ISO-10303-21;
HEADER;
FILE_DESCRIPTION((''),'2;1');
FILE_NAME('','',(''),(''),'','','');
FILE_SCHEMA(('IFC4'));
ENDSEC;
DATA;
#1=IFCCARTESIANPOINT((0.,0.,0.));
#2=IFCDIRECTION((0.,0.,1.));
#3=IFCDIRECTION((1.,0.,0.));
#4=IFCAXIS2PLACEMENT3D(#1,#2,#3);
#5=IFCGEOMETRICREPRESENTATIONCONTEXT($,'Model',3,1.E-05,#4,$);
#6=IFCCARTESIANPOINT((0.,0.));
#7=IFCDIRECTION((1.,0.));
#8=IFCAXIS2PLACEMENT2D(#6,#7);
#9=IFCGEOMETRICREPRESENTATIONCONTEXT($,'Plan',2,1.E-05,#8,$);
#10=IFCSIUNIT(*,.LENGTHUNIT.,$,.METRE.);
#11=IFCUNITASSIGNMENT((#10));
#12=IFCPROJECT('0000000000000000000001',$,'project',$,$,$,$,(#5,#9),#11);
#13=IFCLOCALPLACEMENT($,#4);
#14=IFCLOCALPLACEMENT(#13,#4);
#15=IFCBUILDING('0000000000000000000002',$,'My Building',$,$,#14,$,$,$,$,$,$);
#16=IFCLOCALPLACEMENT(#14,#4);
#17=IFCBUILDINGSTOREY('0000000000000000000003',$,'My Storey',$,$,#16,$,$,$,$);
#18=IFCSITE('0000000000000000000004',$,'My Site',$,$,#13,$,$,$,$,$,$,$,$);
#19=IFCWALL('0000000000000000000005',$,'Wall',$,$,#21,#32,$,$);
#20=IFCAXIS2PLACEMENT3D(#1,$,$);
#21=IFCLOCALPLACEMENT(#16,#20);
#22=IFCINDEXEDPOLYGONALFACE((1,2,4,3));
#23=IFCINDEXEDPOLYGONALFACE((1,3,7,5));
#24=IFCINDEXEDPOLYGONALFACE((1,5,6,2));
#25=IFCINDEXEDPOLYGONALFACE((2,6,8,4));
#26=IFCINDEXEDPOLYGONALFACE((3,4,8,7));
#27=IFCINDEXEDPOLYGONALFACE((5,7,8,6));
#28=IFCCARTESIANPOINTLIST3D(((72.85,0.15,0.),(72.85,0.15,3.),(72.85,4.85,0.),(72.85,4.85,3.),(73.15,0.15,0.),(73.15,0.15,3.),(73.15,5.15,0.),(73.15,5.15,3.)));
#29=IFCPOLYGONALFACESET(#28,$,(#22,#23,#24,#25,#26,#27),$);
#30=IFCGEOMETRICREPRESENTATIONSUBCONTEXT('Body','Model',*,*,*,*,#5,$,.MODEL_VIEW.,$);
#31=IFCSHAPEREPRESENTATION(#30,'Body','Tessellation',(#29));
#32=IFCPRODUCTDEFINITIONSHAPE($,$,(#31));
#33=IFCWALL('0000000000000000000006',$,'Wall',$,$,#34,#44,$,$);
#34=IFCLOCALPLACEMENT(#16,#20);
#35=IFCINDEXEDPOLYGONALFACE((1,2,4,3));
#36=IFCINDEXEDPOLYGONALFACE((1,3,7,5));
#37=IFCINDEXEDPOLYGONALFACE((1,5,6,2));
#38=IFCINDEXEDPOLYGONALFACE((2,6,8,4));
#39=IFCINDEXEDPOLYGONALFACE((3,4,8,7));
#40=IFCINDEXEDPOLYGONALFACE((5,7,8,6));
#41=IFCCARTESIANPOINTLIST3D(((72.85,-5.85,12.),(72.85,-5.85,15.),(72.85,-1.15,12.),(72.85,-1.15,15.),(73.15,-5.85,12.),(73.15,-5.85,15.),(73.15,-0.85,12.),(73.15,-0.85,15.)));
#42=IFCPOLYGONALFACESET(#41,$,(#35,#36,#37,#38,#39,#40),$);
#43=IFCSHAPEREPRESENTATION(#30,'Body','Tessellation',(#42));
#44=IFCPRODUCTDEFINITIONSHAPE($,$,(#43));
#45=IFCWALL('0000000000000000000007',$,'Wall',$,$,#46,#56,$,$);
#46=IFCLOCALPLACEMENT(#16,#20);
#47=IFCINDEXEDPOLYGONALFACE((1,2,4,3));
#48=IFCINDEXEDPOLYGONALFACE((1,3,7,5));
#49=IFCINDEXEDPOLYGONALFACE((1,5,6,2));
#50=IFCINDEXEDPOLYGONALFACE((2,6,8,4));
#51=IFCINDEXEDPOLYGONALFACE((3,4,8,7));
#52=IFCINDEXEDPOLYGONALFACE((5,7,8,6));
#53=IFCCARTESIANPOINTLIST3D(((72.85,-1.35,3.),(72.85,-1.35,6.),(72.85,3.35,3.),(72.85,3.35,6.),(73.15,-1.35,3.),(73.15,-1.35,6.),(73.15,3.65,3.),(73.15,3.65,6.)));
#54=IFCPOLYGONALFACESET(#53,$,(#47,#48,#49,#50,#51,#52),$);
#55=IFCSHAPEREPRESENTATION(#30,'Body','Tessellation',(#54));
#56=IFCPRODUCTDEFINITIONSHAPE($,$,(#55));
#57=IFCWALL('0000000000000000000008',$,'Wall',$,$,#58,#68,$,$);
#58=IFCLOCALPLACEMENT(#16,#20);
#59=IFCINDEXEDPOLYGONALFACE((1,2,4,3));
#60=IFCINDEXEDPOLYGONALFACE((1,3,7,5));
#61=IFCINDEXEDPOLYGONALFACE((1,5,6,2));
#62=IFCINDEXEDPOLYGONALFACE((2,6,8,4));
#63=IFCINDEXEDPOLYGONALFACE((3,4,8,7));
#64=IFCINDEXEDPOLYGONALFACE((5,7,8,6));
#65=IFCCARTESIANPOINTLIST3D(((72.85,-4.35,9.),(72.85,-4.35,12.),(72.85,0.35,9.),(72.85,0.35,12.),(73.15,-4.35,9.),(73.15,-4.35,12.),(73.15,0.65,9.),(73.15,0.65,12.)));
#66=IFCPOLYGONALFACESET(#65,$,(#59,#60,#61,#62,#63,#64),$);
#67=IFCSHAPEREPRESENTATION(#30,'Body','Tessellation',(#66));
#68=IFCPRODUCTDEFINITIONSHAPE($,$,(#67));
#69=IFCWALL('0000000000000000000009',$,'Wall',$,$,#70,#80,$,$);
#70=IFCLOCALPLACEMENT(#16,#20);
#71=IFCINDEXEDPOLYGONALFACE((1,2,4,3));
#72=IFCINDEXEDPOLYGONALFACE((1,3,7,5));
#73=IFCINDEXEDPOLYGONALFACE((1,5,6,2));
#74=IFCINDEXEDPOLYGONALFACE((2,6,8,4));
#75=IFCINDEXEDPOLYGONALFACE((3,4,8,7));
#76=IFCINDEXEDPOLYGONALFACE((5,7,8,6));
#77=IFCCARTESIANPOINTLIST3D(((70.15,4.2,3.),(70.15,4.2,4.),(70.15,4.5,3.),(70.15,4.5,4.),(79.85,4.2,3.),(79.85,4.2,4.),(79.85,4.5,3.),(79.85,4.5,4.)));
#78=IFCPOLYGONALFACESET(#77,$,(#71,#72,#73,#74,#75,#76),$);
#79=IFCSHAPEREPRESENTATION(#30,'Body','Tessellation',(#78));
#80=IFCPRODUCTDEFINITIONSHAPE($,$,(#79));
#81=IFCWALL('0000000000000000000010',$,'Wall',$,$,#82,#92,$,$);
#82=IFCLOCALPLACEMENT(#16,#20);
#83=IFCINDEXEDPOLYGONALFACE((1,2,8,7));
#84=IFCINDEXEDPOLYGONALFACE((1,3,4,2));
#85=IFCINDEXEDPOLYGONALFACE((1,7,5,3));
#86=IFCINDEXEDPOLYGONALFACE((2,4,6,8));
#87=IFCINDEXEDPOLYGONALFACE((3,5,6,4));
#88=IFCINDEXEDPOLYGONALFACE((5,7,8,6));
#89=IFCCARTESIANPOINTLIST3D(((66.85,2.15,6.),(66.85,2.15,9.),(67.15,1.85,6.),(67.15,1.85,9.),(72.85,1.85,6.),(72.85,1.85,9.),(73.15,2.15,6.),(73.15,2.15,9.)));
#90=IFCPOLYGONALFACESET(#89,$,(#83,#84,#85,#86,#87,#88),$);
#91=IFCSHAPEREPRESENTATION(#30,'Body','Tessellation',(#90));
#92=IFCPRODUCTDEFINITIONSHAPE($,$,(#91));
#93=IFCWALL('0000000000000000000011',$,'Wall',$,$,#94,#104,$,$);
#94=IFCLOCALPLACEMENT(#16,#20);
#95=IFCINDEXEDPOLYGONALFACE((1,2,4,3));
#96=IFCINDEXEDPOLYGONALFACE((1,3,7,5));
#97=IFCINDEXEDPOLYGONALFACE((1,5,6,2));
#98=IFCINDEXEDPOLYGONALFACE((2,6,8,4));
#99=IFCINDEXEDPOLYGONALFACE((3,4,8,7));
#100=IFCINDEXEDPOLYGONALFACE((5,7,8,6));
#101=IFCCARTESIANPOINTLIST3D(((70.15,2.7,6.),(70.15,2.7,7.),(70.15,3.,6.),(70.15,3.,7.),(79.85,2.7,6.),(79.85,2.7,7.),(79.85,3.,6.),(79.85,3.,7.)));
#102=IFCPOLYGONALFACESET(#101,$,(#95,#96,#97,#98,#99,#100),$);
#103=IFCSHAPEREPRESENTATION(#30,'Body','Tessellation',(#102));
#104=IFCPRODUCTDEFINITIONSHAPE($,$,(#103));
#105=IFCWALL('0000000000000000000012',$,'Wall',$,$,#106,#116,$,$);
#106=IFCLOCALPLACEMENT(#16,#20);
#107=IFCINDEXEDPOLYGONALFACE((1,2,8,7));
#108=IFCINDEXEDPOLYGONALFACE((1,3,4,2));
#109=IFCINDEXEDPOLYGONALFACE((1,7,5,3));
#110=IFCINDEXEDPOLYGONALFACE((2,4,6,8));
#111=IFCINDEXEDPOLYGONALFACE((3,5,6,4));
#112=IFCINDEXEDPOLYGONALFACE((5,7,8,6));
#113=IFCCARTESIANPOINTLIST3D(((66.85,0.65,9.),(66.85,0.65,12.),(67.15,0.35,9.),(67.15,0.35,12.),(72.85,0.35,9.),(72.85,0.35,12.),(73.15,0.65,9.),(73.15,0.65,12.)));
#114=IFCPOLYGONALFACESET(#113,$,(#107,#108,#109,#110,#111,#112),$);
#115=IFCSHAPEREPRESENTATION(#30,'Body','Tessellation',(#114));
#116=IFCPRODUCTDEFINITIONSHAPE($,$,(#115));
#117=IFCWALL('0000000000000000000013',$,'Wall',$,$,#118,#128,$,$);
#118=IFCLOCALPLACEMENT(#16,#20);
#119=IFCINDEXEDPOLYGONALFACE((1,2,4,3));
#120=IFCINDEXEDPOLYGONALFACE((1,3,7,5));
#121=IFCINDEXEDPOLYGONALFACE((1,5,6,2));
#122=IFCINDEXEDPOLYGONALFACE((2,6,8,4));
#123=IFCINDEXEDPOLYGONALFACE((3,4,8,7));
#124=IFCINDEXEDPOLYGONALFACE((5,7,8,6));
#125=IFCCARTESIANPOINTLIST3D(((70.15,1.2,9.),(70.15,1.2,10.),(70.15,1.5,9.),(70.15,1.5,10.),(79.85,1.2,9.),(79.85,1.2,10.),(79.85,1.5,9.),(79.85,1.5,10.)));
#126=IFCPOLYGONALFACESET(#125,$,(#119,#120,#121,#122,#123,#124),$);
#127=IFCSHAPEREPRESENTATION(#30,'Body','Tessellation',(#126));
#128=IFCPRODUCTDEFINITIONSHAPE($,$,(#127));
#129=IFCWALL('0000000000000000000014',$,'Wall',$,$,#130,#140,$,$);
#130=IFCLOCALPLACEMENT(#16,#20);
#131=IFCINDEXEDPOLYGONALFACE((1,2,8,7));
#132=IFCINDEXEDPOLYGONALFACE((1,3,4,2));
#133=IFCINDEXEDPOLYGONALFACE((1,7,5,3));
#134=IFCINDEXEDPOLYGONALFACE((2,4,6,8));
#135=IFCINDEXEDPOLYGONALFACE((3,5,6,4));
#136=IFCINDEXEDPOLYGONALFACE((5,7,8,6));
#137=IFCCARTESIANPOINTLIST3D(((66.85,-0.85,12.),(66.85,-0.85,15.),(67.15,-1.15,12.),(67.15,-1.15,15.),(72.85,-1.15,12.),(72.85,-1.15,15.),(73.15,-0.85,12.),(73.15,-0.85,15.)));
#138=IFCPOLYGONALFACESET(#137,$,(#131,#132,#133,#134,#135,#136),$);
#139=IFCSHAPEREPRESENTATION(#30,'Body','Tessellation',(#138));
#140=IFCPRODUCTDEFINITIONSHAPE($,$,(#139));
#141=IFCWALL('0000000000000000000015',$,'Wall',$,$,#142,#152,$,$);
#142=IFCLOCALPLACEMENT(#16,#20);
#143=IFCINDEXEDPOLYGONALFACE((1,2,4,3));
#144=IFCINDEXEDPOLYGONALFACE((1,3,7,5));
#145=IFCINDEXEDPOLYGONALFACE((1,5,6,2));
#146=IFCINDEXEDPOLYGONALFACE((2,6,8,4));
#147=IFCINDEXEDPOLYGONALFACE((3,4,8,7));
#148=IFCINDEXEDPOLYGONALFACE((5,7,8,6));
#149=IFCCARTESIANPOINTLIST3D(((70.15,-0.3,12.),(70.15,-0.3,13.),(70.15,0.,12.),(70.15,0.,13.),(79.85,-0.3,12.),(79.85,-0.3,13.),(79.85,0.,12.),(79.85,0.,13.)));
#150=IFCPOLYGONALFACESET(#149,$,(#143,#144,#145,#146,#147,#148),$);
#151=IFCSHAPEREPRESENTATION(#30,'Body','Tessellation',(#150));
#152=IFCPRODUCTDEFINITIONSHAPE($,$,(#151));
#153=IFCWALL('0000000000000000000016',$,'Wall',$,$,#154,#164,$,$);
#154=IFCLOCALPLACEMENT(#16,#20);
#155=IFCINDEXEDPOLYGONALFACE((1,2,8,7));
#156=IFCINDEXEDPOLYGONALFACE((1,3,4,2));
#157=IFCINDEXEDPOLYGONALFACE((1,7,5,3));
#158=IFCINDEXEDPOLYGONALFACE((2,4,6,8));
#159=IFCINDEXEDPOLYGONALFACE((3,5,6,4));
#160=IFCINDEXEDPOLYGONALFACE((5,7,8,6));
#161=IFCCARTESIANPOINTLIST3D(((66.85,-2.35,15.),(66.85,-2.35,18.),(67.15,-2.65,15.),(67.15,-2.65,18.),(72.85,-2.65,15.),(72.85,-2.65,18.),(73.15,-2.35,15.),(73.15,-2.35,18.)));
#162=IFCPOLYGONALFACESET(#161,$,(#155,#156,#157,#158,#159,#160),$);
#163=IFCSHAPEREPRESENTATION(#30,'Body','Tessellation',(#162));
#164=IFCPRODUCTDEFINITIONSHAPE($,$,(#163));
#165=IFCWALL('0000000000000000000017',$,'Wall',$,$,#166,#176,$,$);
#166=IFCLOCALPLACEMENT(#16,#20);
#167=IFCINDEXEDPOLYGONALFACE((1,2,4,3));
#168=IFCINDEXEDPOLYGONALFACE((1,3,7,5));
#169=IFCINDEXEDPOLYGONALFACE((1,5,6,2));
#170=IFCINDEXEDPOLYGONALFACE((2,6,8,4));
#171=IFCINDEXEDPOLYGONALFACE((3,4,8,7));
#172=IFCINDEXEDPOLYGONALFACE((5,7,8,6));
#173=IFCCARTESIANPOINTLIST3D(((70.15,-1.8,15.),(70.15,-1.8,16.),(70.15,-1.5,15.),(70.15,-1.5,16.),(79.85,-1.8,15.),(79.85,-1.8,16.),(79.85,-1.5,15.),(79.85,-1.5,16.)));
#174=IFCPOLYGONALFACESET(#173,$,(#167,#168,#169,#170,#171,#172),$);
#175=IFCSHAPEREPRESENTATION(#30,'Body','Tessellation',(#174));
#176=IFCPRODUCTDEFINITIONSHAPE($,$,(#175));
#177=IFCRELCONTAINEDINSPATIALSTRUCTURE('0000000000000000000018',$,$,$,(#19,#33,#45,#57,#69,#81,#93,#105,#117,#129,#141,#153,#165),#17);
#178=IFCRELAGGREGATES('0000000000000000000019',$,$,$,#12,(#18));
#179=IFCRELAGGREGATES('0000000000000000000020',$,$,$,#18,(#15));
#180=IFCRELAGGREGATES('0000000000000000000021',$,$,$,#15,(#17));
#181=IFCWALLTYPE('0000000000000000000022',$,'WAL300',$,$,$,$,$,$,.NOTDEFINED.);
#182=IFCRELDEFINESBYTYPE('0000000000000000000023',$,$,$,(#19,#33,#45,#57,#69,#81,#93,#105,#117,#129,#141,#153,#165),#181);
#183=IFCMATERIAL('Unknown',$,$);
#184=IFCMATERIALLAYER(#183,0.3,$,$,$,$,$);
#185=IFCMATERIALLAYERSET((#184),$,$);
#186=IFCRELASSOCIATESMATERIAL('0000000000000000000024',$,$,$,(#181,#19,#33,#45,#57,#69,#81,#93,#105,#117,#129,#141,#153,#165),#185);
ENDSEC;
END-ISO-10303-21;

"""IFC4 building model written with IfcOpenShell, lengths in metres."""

from ifc_helpers import new_model, si_unit, frame, origin_with_axes, origin_2d_with_axis, place, context, subcontext, project, spatial, line, indexed_curve, outline, extrude, material, layer, layer_set, layer_usage, type_object, element, save


model = new_model("IFC4")

# Units and contexts
model_context = context("Model", 3, precision=1e-05, world=origin_with_axes())
plan_context = context("Plan", 2, precision=1e-05, world=origin_2d_with_axis())
body_context = subcontext(model_context, "Body", "Model", "MODEL_VIEW")
ifc_project = project(units=[si_unit("LENGTHUNIT", "METRE")], contexts=[model_context, plan_context])

# Site, building, storey
site_placement = place(None, origin_with_axes())
site = spatial("IfcSite", under=ifc_project, at=site_placement, Name="My Site")
building_placement = place(site_placement, origin_with_axes())
building = spatial("IfcBuilding", under=site, at=building_placement, Name="My Building")
storey_placement = place(building_placement, origin_with_axes())
storey = spatial("IfcBuildingStorey", under=building, at=storey_placement, Name="My Storey")

# Walls
ifc_material = material(Name="Unknown")
ifc_layer = layer(ifc_material, 0.3)
ifc_layer_set = layer_set([ifc_layer])
wall_type = type_object("IfcWallType", Name="WAL300", PredefinedType="NOTDEFINED", material=ifc_layer_set)
ifc_layer_usage_1 = layer_usage(ifc_layer_set, "AXIS2", "POSITIVE", -0.15)
wall_1_placement = place(storey_placement, frame((73.0, 0.0, 0.0), z_axis=(0.0, 0.0, 1.0), x_axis=(0.0, 1.0, 0.0)))
element("IfcWall", 1, at=wall_1_placement, inside=storey, type_object=wall_type, material=ifc_layer_usage_1, Name="Wall", context=body_context, shape_type="SweptSolid", body=[
    extrude(outline(indexed_curve([(0.15, -0.15), (0.15, 0.15), (4.85, 0.15), (5.15, -0.15)], segments=[line(1, 2, 3, 4, 1)])), origin_with_axes(), (0.0, 0.0, 1.0), 3.0),
])
ifc_layer_usage_2 = layer_usage(ifc_layer_set, "AXIS2", "POSITIVE", -0.15)
wall_2_placement = place(storey_placement, frame((73.0, -6.0, 12.0), z_axis=(0.0, 0.0, 1.0), x_axis=(0.0, 1.0, 0.0)))
element("IfcWall", 2, at=wall_2_placement, inside=storey, type_object=wall_type, material=ifc_layer_usage_2, Name="Wall", context=body_context, shape_type="SweptSolid", body=[
    extrude(outline(indexed_curve([(0.15, -0.15), (0.15, 0.15), (4.85, 0.15), (5.15, -0.15)], segments=[line(1, 2, 3, 4, 1)])), origin_with_axes(), (0.0, 0.0, 1.0), 3.0),
])
ifc_layer_usage_3 = layer_usage(ifc_layer_set, "AXIS2", "POSITIVE", -0.15)
wall_3_placement = place(storey_placement, frame((73.0, -1.5, 3.0), z_axis=(0.0, 0.0, 1.0), x_axis=(0.0, 1.0, 0.0)))
element("IfcWall", 3, at=wall_3_placement, inside=storey, type_object=wall_type, material=ifc_layer_usage_3, Name="Wall", context=body_context, shape_type="SweptSolid", body=[
    extrude(outline(indexed_curve([(0.15, -0.15), (0.15, 0.15), (4.85, 0.15), (5.15, -0.15)], segments=[line(1, 2, 3, 4, 1)])), origin_with_axes(), (0.0, 0.0, 1.0), 3.0),
])
ifc_layer_usage_4 = layer_usage(ifc_layer_set, "AXIS2", "POSITIVE", -0.15)
wall_4_placement = place(storey_placement, frame((73.0, -4.5, 9.0), z_axis=(0.0, 0.0, 1.0), x_axis=(0.0, 1.0, 0.0)))
element("IfcWall", 4, at=wall_4_placement, inside=storey, type_object=wall_type, material=ifc_layer_usage_4, Name="Wall", context=body_context, shape_type="SweptSolid", body=[
    extrude(outline(indexed_curve([(0.15, -0.15), (0.15, 0.15), (4.85, 0.15), (5.15, -0.15)], segments=[line(1, 2, 3, 4, 1)])), origin_with_axes(), (0.0, 0.0, 1.0), 3.0),
])
ifc_layer_usage_5 = layer_usage(ifc_layer_set, "AXIS2", "POSITIVE", -0.3)
wall_5_placement = place(storey_placement, frame((70.15, 4.5, 3.0), z_axis=(0.0, 0.0, 1.0), x_axis=(1.0, 0.0, 0.0)))
element("IfcWall", 5, at=wall_5_placement, inside=storey, type_object=wall_type, material=ifc_layer_usage_5, Name="Wall", context=body_context, shape_type="SweptSolid", body=[
    extrude(outline(indexed_curve([(0.0, -0.3), (0.0, 0.0), (9.7, 0.0), (9.7, -0.3)], segments=[line(1, 2, 3, 4, 1)])), origin_with_axes(), (0.0, 0.0, 1.0), 1.0),
])
ifc_layer_usage_6 = layer_usage(ifc_layer_set, "AXIS2", "POSITIVE", -0.15)
wall_6_placement = place(storey_placement, frame((67.0, 2.0, 6.0), z_axis=(0.0, 0.0, 1.0), x_axis=(1.0, 0.0, 0.0)))
element("IfcWall", 6, at=wall_6_placement, inside=storey, type_object=wall_type, material=ifc_layer_usage_6, Name="Wall", context=body_context, shape_type="SweptSolid", body=[
    extrude(outline(indexed_curve([(0.15, -0.15), (-0.15, 0.15), (6.15, 0.15), (5.85, -0.15)], segments=[line(1, 2, 3, 4, 1)])), origin_with_axes(), (0.0, 0.0, 1.0), 3.0),
])
ifc_layer_usage_7 = layer_usage(ifc_layer_set, "AXIS2", "POSITIVE", -0.3)
wall_7_placement = place(storey_placement, frame((70.15, 3.0, 6.0), z_axis=(0.0, 0.0, 1.0), x_axis=(1.0, 0.0, 0.0)))
element("IfcWall", 7, at=wall_7_placement, inside=storey, type_object=wall_type, material=ifc_layer_usage_7, Name="Wall", context=body_context, shape_type="SweptSolid", body=[
    extrude(outline(indexed_curve([(0.0, -0.3), (0.0, 0.0), (9.7, 0.0), (9.7, -0.3)], segments=[line(1, 2, 3, 4, 1)])), origin_with_axes(), (0.0, 0.0, 1.0), 1.0),
])
ifc_layer_usage_8 = layer_usage(ifc_layer_set, "AXIS2", "POSITIVE", -0.15)
wall_8_placement = place(storey_placement, frame((67.0, 0.5, 9.0), z_axis=(0.0, 0.0, 1.0), x_axis=(1.0, 0.0, 0.0)))
element("IfcWall", 8, at=wall_8_placement, inside=storey, type_object=wall_type, material=ifc_layer_usage_8, Name="Wall", context=body_context, shape_type="SweptSolid", body=[
    extrude(outline(indexed_curve([(0.15, -0.15), (-0.15, 0.15), (6.15, 0.15), (5.85, -0.15)], segments=[line(1, 2, 3, 4, 1)])), origin_with_axes(), (0.0, 0.0, 1.0), 3.0),
])
ifc_layer_usage_9 = layer_usage(ifc_layer_set, "AXIS2", "POSITIVE", -0.3)
wall_9_placement = place(storey_placement, frame((70.15, 1.5, 9.0), z_axis=(0.0, 0.0, 1.0), x_axis=(1.0, 0.0, 0.0)))
element("IfcWall", 9, at=wall_9_placement, inside=storey, type_object=wall_type, material=ifc_layer_usage_9, Name="Wall", context=body_context, shape_type="SweptSolid", body=[
    extrude(outline(indexed_curve([(0.0, -0.3), (0.0, 0.0), (9.7, 0.0), (9.7, -0.3)], segments=[line(1, 2, 3, 4, 1)])), origin_with_axes(), (0.0, 0.0, 1.0), 1.0),
])
ifc_layer_usage_10 = layer_usage(ifc_layer_set, "AXIS2", "POSITIVE", -0.15)
wall_10_placement = place(storey_placement, frame((67.0, -1.0, 12.0), z_axis=(0.0, 0.0, 1.0), x_axis=(1.0, 0.0, 0.0)))
element("IfcWall", 10, at=wall_10_placement, inside=storey, type_object=wall_type, material=ifc_layer_usage_10, Name="Wall", context=body_context, shape_type="SweptSolid", body=[
    extrude(outline(indexed_curve([(0.15, -0.15), (-0.15, 0.15), (6.15, 0.15), (5.85, -0.15)], segments=[line(1, 2, 3, 4, 1)])), origin_with_axes(), (0.0, 0.0, 1.0), 3.0),
])
ifc_layer_usage_11 = layer_usage(ifc_layer_set, "AXIS2", "POSITIVE", -0.3)
wall_11_placement = place(storey_placement, frame((70.15, 0.0, 12.0), z_axis=(0.0, 0.0, 1.0), x_axis=(1.0, 0.0, 0.0)))
element("IfcWall", 11, at=wall_11_placement, inside=storey, type_object=wall_type, material=ifc_layer_usage_11, Name="Wall", context=body_context, shape_type="SweptSolid", body=[
    extrude(outline(indexed_curve([(0.0, -0.3), (0.0, 0.0), (9.7, 0.0), (9.7, -0.3)], segments=[line(1, 2, 3, 4, 1)])), origin_with_axes(), (0.0, 0.0, 1.0), 1.0),
])
ifc_layer_usage_12 = layer_usage(ifc_layer_set, "AXIS2", "POSITIVE", -0.15)
wall_12_placement = place(storey_placement, frame((67.0, -2.5, 15.0), z_axis=(0.0, 0.0, 1.0), x_axis=(1.0, 0.0, 0.0)))
element("IfcWall", 12, at=wall_12_placement, inside=storey, type_object=wall_type, material=ifc_layer_usage_12, Name="Wall", context=body_context, shape_type="SweptSolid", body=[
    extrude(outline(indexed_curve([(0.15, -0.15), (-0.15, 0.15), (6.15, 0.15), (5.85, -0.15)], segments=[line(1, 2, 3, 4, 1)])), origin_with_axes(), (0.0, 0.0, 1.0), 3.0),
])
ifc_layer_usage_13 = layer_usage(ifc_layer_set, "AXIS2", "POSITIVE", -0.3)
wall_13_placement = place(storey_placement, frame((70.15, -1.5, 15.0), z_axis=(0.0, 0.0, 1.0), x_axis=(1.0, 0.0, 0.0)))
element("IfcWall", 13, at=wall_13_placement, inside=storey, type_object=wall_type, material=ifc_layer_usage_13, Name="Wall", context=body_context, shape_type="SweptSolid", body=[
    extrude(outline(indexed_curve([(0.0, -0.3), (0.0, 0.0), (9.7, 0.0), (9.7, -0.3)], segments=[line(1, 2, 3, 4, 1)])), origin_with_axes(), (0.0, 0.0, 1.0), 1.0),
])

save(model, "model.ifc")
